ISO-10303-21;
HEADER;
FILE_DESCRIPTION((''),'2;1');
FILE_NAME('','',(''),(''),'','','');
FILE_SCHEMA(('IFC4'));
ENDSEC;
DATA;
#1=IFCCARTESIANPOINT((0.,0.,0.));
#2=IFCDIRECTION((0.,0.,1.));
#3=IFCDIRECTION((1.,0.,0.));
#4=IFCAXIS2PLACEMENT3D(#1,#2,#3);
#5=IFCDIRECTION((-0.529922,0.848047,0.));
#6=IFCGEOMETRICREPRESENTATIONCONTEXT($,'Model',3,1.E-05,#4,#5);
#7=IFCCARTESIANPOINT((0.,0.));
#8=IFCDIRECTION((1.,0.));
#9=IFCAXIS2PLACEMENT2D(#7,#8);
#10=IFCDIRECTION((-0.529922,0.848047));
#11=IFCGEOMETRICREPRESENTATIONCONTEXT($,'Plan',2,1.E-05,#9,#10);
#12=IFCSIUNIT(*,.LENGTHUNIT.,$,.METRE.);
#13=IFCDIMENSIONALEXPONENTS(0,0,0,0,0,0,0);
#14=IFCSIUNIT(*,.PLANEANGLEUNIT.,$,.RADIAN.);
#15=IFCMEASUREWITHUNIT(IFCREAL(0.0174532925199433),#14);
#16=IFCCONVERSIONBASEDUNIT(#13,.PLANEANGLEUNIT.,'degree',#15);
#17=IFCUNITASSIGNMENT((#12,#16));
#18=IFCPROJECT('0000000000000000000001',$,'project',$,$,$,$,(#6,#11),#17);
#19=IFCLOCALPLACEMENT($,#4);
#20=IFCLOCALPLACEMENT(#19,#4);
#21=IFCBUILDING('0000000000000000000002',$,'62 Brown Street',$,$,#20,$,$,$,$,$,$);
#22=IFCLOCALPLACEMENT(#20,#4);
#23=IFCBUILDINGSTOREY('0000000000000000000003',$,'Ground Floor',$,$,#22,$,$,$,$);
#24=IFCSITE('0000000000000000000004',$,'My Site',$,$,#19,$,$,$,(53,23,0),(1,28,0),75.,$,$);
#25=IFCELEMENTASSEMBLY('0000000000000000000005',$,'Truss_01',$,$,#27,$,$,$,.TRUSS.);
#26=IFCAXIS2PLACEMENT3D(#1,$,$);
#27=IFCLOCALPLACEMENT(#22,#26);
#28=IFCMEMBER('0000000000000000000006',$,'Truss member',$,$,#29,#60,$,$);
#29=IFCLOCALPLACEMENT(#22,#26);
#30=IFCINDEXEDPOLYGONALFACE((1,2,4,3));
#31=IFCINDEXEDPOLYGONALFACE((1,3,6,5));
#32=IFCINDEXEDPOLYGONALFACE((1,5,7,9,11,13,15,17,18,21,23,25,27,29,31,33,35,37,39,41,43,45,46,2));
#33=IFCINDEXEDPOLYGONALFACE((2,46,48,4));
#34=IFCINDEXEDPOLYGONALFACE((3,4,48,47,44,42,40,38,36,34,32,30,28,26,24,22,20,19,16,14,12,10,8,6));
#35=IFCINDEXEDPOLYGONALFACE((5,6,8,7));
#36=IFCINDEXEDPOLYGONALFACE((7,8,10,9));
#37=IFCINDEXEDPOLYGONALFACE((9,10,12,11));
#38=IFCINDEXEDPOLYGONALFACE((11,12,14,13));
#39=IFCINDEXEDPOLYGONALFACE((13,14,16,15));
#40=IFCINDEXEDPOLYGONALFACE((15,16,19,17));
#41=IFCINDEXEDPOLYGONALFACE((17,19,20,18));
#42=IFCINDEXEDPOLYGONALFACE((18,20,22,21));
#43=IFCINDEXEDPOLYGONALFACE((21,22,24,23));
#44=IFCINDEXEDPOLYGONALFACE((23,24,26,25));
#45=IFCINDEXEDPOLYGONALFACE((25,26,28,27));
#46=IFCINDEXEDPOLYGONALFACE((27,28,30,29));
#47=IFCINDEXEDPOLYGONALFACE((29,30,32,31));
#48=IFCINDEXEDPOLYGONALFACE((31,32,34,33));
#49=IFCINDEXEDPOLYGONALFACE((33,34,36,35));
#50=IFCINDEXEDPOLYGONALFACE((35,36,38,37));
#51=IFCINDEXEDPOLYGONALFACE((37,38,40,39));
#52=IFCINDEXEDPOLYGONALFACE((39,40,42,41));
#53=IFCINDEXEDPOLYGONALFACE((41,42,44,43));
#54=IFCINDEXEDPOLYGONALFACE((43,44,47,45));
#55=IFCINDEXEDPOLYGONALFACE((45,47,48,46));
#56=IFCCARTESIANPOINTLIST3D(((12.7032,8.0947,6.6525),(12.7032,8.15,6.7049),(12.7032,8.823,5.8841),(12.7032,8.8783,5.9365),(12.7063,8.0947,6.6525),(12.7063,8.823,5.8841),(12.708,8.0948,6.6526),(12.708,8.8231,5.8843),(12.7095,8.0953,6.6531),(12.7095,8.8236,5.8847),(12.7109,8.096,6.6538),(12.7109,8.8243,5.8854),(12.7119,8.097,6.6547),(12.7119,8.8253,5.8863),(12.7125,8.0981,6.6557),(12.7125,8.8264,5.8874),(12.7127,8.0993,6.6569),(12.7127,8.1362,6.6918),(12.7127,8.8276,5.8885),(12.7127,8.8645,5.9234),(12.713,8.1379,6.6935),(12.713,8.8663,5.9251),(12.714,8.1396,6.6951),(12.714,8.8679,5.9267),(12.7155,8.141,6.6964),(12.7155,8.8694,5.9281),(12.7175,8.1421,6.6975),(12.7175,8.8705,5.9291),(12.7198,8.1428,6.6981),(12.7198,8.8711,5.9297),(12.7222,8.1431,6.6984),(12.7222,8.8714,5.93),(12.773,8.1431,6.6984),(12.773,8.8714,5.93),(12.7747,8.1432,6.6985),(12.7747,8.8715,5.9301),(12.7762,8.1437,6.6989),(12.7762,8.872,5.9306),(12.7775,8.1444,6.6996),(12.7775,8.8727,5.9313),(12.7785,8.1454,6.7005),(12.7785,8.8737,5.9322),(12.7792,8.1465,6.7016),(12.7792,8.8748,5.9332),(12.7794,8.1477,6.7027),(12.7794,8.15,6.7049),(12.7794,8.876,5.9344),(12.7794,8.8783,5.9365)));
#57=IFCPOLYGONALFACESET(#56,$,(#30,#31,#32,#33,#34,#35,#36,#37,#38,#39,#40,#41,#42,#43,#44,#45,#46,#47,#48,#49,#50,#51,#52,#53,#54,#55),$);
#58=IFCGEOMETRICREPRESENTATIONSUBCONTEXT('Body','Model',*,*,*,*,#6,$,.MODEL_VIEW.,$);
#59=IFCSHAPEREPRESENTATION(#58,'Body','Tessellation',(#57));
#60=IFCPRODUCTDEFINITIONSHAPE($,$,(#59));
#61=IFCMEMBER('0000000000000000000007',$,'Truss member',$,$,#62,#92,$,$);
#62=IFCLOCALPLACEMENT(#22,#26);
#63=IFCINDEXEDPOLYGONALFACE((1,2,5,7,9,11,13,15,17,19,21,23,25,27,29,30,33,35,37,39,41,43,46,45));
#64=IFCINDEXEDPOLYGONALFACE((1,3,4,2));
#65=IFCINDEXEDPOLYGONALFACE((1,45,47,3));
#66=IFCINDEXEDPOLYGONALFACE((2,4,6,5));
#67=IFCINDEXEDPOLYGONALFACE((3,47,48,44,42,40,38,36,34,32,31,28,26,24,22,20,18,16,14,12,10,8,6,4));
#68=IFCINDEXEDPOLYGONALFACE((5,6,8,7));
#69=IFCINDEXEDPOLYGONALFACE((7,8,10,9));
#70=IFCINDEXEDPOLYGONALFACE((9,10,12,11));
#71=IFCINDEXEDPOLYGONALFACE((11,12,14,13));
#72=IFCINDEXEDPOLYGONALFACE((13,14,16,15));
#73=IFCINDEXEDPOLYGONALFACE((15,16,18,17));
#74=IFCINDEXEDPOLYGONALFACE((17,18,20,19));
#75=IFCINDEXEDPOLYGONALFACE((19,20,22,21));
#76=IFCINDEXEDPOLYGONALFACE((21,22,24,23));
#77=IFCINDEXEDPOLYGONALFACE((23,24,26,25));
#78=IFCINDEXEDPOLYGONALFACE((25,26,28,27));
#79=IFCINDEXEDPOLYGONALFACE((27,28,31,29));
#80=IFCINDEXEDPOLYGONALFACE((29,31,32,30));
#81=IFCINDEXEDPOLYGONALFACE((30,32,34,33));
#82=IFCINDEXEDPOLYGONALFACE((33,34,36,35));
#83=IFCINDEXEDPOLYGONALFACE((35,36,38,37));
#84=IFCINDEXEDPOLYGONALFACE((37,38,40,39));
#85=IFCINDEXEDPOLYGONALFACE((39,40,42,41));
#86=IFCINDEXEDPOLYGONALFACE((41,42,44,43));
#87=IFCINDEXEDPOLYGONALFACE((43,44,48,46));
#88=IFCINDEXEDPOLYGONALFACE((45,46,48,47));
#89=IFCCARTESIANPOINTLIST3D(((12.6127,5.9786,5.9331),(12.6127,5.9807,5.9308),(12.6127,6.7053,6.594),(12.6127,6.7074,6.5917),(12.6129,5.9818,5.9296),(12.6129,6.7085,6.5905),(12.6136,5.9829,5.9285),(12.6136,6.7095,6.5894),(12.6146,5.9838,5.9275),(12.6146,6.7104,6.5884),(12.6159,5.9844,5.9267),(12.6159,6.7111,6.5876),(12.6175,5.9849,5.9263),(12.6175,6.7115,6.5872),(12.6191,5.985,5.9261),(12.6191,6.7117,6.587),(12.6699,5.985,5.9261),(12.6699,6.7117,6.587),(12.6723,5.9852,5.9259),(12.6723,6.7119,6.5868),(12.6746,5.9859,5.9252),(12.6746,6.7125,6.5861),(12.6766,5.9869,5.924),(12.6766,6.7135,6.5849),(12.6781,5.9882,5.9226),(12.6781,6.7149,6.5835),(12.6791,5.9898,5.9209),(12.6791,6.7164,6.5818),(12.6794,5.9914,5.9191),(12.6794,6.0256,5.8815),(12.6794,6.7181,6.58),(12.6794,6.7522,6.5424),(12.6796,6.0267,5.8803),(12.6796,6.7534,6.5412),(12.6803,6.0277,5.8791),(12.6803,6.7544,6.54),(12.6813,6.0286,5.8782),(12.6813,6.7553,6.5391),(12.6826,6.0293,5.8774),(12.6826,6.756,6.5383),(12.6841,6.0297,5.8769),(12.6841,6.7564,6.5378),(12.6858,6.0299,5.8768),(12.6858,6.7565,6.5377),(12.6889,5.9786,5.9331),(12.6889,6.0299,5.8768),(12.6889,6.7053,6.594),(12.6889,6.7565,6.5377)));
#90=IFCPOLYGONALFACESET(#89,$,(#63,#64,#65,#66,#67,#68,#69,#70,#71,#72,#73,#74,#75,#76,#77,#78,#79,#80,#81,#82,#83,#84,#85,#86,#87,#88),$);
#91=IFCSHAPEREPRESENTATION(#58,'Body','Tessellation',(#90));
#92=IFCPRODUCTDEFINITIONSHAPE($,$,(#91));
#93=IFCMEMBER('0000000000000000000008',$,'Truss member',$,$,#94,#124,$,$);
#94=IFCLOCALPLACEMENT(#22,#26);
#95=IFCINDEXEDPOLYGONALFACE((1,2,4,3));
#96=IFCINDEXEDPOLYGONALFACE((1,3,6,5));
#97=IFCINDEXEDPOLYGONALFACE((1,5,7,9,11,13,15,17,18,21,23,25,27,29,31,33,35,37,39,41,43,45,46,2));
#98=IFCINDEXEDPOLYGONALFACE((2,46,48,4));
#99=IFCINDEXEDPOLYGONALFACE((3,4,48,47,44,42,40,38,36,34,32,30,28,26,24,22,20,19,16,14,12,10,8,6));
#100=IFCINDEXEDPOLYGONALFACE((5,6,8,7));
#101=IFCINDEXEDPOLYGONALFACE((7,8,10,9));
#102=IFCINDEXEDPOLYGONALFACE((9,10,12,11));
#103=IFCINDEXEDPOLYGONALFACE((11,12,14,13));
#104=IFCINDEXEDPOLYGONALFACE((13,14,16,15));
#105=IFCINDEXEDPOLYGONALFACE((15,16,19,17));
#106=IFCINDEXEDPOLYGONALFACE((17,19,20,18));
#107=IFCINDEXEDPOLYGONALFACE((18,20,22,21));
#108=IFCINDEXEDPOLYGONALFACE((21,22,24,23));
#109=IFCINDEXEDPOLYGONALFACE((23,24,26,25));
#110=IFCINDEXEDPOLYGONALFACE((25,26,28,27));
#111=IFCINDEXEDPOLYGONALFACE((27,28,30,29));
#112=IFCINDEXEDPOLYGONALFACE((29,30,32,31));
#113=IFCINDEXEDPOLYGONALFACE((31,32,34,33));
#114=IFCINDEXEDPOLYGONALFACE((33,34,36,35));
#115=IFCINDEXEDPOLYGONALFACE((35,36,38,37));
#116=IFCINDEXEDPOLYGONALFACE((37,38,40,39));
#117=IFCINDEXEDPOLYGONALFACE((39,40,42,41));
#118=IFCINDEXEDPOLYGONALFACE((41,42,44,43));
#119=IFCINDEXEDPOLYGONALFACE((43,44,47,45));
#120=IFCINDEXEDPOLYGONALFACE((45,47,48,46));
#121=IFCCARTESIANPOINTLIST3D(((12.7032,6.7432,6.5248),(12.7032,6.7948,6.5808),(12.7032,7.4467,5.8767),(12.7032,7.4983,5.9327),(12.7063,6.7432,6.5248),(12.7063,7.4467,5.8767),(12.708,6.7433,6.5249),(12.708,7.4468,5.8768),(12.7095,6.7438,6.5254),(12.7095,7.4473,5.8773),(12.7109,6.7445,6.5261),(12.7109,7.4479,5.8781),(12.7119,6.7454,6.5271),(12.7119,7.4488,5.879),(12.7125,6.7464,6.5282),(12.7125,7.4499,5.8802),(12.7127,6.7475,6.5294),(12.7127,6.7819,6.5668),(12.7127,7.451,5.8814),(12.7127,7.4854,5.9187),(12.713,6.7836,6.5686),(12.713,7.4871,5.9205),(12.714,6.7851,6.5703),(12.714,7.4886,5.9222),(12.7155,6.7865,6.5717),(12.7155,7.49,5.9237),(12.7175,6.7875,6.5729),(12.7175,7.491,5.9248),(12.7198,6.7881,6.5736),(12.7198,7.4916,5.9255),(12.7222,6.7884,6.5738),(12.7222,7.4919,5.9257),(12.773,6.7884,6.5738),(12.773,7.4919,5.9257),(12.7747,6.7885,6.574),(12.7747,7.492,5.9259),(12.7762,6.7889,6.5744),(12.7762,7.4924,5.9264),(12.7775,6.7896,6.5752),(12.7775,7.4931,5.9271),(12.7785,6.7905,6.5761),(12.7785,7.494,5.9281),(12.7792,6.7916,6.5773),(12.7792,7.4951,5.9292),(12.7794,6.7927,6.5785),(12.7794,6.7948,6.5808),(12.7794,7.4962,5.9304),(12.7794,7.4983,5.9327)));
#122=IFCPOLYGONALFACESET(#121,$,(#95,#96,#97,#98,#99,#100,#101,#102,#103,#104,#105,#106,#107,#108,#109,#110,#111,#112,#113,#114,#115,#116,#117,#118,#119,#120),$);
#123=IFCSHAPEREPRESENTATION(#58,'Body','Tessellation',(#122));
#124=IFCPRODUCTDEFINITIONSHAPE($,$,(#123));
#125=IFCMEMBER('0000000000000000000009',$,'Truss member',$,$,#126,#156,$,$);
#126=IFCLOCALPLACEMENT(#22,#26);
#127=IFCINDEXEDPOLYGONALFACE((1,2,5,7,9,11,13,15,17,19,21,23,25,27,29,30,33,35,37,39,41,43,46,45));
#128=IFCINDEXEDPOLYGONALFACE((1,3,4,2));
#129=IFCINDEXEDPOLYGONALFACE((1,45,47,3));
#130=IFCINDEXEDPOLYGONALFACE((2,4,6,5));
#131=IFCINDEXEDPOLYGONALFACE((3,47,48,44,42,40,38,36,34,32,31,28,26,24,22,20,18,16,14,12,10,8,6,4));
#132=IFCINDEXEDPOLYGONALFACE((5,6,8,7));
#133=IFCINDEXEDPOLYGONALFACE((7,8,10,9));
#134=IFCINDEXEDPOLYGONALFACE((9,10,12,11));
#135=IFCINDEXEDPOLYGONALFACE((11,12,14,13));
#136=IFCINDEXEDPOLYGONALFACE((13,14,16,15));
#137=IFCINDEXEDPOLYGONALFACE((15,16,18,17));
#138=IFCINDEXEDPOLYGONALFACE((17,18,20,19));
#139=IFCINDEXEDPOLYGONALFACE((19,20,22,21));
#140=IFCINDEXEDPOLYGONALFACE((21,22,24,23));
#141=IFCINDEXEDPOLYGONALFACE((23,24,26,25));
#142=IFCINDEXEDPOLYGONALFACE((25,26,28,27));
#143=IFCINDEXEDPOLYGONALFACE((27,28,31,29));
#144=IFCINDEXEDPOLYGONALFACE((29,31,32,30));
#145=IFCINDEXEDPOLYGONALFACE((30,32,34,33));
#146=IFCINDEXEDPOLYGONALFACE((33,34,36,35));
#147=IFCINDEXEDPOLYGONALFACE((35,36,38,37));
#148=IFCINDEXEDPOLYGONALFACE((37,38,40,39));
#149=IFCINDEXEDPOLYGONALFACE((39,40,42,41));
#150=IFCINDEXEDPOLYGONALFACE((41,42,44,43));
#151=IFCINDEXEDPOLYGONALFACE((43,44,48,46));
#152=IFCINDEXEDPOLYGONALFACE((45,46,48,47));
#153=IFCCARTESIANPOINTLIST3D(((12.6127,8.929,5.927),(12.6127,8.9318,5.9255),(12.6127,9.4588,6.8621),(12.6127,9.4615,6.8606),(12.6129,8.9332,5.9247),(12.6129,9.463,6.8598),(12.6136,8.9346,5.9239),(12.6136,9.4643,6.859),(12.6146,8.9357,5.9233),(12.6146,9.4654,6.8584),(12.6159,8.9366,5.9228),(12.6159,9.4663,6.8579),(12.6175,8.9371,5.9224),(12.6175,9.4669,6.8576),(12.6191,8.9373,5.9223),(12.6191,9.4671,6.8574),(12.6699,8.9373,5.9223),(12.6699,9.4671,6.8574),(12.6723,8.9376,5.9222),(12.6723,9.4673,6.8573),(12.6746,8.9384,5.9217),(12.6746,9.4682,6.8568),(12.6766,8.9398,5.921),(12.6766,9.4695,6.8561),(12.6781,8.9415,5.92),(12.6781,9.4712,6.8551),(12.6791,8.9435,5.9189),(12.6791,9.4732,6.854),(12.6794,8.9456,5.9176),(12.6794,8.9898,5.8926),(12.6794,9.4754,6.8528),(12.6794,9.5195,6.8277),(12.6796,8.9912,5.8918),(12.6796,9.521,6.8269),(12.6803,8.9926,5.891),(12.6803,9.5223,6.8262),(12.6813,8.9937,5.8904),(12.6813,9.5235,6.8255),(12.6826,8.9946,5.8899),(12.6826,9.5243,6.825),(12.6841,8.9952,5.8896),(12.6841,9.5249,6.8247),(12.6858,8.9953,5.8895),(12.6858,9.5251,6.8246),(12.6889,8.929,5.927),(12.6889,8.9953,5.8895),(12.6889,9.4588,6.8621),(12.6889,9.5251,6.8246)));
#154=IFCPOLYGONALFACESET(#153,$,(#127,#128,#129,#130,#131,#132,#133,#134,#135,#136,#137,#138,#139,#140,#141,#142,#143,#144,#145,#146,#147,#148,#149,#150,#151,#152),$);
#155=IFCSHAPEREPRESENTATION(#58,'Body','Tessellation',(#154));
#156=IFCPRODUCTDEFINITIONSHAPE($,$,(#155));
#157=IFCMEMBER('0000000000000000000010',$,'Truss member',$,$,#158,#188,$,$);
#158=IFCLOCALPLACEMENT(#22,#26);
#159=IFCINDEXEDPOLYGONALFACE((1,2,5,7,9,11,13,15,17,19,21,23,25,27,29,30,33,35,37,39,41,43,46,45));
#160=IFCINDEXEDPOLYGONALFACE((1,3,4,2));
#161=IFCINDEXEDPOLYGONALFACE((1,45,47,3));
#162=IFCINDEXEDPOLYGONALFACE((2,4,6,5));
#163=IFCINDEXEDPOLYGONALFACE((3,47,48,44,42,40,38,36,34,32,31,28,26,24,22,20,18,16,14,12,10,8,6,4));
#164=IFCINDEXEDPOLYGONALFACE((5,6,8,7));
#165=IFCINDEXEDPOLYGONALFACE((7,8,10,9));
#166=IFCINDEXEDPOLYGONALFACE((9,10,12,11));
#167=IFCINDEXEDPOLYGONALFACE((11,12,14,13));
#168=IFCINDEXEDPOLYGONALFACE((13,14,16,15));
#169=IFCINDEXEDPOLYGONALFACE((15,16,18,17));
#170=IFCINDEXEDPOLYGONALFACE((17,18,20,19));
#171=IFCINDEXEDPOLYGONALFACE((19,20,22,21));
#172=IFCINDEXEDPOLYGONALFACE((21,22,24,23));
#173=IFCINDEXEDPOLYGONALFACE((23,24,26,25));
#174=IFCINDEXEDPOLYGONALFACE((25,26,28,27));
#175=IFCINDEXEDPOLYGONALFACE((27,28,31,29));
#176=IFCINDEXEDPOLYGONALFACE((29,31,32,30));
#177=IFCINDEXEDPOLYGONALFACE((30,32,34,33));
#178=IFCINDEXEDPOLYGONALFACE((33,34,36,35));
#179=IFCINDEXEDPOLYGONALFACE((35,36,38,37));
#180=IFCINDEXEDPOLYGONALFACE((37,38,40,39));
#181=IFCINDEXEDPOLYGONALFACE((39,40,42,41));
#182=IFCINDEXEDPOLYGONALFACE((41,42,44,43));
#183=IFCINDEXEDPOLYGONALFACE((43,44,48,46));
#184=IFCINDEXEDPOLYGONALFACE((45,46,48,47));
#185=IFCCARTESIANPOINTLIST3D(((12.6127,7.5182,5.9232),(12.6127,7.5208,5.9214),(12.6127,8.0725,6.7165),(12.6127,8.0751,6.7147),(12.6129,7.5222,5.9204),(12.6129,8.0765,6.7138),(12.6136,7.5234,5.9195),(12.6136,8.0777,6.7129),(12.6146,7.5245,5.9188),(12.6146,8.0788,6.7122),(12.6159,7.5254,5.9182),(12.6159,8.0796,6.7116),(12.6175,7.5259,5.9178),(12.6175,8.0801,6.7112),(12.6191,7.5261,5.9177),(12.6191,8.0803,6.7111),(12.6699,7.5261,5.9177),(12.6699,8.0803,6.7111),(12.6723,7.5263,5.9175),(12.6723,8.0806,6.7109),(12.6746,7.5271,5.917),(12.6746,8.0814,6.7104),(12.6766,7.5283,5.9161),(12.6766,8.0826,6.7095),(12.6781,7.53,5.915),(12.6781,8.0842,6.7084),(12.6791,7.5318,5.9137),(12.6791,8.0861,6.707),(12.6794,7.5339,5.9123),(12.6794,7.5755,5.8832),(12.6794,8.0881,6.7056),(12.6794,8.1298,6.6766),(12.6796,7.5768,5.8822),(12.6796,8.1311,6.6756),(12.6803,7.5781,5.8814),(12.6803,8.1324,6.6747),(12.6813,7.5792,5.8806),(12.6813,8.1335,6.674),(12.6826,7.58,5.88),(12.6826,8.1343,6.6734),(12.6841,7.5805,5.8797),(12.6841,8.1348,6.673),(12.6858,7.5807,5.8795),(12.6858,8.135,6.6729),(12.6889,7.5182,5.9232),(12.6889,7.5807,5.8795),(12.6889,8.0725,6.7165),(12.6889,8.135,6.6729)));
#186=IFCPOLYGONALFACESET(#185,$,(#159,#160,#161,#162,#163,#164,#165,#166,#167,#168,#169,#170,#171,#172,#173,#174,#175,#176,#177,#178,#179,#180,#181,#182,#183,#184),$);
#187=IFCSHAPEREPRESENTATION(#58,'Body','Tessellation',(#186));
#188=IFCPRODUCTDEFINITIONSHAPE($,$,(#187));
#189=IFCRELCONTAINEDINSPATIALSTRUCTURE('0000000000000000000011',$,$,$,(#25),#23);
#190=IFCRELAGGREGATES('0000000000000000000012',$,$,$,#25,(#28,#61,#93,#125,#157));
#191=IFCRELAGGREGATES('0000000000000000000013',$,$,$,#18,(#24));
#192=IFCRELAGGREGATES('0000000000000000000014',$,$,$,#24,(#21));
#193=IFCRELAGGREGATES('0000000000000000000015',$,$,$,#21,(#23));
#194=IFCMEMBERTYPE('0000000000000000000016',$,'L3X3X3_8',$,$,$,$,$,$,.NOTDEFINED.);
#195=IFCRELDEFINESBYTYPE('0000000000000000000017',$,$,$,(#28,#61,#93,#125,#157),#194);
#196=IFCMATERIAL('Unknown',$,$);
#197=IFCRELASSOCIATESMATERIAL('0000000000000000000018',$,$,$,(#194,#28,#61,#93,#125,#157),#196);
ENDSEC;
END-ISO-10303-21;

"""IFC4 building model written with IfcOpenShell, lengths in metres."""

from ifc_helpers import new_model, entity, si_unit, converted_unit, direction, frame, origin_with_axes, origin_2d_with_axis, place, context, subcontext, project, spatial, l_section, extrude, material, material_profile, profile_set, profile_usage, type_object, element, aggregate, save


model = new_model("IFC4")

# Units and contexts
model_context = context("Model", 3, precision=1e-05, world=origin_with_axes(), true_north=direction((-0.529922, 0.848047, 0.0)))
plan_context = context("Plan", 2, precision=1e-05, world=origin_2d_with_axis(), true_north=direction((-0.529922, 0.848047)))
body_context_1 = subcontext(model_context, "Body", "Model", "MODEL_VIEW")
ifc_project = project(units=[si_unit("LENGTHUNIT", "METRE"), converted_unit("PLANEANGLEUNIT", "degree", entity("IfcReal", 0.0174532925199433), si_unit("PLANEANGLEUNIT", "RADIAN"), dimensions=[0, 0, 0, 0, 0, 0, 0])], contexts=[model_context, plan_context])

# Site, building, storey
site_placement = place(None, origin_with_axes())
site = spatial("IfcSite", under=ifc_project, at=site_placement, Name="My Site", RefLatitude=(53, 23, 0), RefLongitude=(1, 28, 0), RefElevation=75.0)
building_placement = place(site_placement, origin_with_axes())
building = spatial("IfcBuilding", under=site, at=building_placement, Name="62 Brown Street")
storey_placement = place(building_placement, origin_with_axes())
storey = spatial("IfcBuildingStorey", under=building, at=storey_placement, Name="Ground Floor")

# Element assembly, members
ifc_material_1 = material(Name="Unknown")
ifc_material_profile_1 = material_profile(ifc_material_1, l_section(Depth=0.0762, Width=0.0762, Thickness=0.0095, FilletRadius=0.0095, EdgeRadius=0.0064))
ifc_profile_set_1 = profile_set([ifc_material_profile_1])
member_type_1 = type_object("IfcMemberType", Name="L3X3X3_8", PredefinedType="NOTDEFINED", material=ifc_profile_set_1)
assembly_1_placement = place(storey_placement, frame((12.7032, 10.4288, 6.9738), z_axis=(0.0, 0.0, 1.0), x_axis=(1.0, 0.0, 0.0)))
assembly_1 = element("IfcElementAssembly", 1, at=assembly_1_placement, inside=storey, Name="Truss_01", PredefinedType="TRUSS")
ifc_profile_usage_1 = profile_usage(ifc_profile_set_1, cardinal=5)
member_1_placement = place(assembly_1_placement, frame((0.0381, -2.3065, -0.2951), z_axis=(-0.000001, 0.687927, -0.72578), x_axis=(1.0, 0.0, 0.0)))
member_1 = element("IfcMember", 2, at=member_1_placement, type_object=member_type_1, material=ifc_profile_usage_1, Name="Truss member", context=body_context_1, shape_type="SweptSolid", body=[
    extrude(l_section(Depth=0.0762, Width=0.0762, Thickness=0.0095, FilletRadius=0.0095, EdgeRadius=0.0064), origin_with_axes(), (0.0, 0.0, 1.0), 1.0587),
])
ifc_profile_usage_2 = profile_usage(ifc_profile_set_1, cardinal=5)
member_2_placement = place(assembly_1_placement, frame((-0.0524, -3.6979, -0.4079), z_axis=(0.000001, -0.739785, -0.672843), x_axis=(-1.0, -0.000001, 0.0)))
member_2 = element("IfcMember", 3, at=member_2_placement, type_object=member_type_1, material=ifc_profile_usage_2, Name="Truss member", context=body_context_1, shape_type="SweptSolid", body=[
    extrude(l_section(Depth=0.0762, Width=0.0762, Thickness=0.0095, FilletRadius=0.0095, EdgeRadius=0.0064), origin_with_axes(), (0.0, 0.0, 1.0), 0.9823),
])
ifc_profile_usage_3 = profile_usage(ifc_profile_set_1, cardinal=5)
member_3_placement = place(assembly_1_placement, frame((0.0381, -3.6598, -0.421), z_axis=(-0.000001, 0.735484, -0.677542), x_axis=(1.0, 0.000001, 0.0)))
member_3 = element("IfcMember", 4, at=member_3_placement, type_object=member_type_1, material=ifc_profile_usage_3, Name="Truss member", context=body_context_1, shape_type="SweptSolid", body=[
    extrude(l_section(Depth=0.0762, Width=0.0762, Thickness=0.0095, FilletRadius=0.0095, EdgeRadius=0.0064), origin_with_axes(), (0.0, 0.0, 1.0), 0.9565),
])
ifc_profile_usage_4 = profile_usage(ifc_profile_set_1, cardinal=5)
member_4_placement = place(assembly_1_placement, frame((-0.0524, -0.9369, -0.1304), z_axis=(0.0, -0.492899, -0.870086), x_axis=(-1.0, 0.0, 0.0)))
member_4 = element("IfcMember", 5, at=member_4_placement, type_object=member_type_1, material=ifc_profile_usage_4, Name="Truss member", context=body_context_1, shape_type="SweptSolid", body=[
    extrude(l_section(Depth=0.0762, Width=0.0762, Thickness=0.0095, FilletRadius=0.0095, EdgeRadius=0.0064), origin_with_axes(), (0.0, 0.0, 1.0), 1.0747),
])
ifc_profile_usage_5 = profile_usage(ifc_profile_set_1, cardinal=5)
member_5_placement = place(assembly_1_placement, frame((-0.0524, -2.325, -0.279), z_axis=(0.000001, -0.572709, -0.819759), x_axis=(-1.0, -0.000001, 0.0)))
member_5 = element("IfcMember", 6, at=member_5_placement, type_object=member_type_1, material=ifc_profile_usage_5, Name="Truss member", context=body_context_1, shape_type="SweptSolid", body=[
    extrude(l_section(Depth=0.0762, Width=0.0762, Thickness=0.0095, FilletRadius=0.0095, EdgeRadius=0.0064), origin_with_axes(), (0.0, 0.0, 1.0), 0.9678),
])

aggregate(assembly_1, [member_1, member_2, member_3, member_4, member_5])

save(model, "model.ifc")
